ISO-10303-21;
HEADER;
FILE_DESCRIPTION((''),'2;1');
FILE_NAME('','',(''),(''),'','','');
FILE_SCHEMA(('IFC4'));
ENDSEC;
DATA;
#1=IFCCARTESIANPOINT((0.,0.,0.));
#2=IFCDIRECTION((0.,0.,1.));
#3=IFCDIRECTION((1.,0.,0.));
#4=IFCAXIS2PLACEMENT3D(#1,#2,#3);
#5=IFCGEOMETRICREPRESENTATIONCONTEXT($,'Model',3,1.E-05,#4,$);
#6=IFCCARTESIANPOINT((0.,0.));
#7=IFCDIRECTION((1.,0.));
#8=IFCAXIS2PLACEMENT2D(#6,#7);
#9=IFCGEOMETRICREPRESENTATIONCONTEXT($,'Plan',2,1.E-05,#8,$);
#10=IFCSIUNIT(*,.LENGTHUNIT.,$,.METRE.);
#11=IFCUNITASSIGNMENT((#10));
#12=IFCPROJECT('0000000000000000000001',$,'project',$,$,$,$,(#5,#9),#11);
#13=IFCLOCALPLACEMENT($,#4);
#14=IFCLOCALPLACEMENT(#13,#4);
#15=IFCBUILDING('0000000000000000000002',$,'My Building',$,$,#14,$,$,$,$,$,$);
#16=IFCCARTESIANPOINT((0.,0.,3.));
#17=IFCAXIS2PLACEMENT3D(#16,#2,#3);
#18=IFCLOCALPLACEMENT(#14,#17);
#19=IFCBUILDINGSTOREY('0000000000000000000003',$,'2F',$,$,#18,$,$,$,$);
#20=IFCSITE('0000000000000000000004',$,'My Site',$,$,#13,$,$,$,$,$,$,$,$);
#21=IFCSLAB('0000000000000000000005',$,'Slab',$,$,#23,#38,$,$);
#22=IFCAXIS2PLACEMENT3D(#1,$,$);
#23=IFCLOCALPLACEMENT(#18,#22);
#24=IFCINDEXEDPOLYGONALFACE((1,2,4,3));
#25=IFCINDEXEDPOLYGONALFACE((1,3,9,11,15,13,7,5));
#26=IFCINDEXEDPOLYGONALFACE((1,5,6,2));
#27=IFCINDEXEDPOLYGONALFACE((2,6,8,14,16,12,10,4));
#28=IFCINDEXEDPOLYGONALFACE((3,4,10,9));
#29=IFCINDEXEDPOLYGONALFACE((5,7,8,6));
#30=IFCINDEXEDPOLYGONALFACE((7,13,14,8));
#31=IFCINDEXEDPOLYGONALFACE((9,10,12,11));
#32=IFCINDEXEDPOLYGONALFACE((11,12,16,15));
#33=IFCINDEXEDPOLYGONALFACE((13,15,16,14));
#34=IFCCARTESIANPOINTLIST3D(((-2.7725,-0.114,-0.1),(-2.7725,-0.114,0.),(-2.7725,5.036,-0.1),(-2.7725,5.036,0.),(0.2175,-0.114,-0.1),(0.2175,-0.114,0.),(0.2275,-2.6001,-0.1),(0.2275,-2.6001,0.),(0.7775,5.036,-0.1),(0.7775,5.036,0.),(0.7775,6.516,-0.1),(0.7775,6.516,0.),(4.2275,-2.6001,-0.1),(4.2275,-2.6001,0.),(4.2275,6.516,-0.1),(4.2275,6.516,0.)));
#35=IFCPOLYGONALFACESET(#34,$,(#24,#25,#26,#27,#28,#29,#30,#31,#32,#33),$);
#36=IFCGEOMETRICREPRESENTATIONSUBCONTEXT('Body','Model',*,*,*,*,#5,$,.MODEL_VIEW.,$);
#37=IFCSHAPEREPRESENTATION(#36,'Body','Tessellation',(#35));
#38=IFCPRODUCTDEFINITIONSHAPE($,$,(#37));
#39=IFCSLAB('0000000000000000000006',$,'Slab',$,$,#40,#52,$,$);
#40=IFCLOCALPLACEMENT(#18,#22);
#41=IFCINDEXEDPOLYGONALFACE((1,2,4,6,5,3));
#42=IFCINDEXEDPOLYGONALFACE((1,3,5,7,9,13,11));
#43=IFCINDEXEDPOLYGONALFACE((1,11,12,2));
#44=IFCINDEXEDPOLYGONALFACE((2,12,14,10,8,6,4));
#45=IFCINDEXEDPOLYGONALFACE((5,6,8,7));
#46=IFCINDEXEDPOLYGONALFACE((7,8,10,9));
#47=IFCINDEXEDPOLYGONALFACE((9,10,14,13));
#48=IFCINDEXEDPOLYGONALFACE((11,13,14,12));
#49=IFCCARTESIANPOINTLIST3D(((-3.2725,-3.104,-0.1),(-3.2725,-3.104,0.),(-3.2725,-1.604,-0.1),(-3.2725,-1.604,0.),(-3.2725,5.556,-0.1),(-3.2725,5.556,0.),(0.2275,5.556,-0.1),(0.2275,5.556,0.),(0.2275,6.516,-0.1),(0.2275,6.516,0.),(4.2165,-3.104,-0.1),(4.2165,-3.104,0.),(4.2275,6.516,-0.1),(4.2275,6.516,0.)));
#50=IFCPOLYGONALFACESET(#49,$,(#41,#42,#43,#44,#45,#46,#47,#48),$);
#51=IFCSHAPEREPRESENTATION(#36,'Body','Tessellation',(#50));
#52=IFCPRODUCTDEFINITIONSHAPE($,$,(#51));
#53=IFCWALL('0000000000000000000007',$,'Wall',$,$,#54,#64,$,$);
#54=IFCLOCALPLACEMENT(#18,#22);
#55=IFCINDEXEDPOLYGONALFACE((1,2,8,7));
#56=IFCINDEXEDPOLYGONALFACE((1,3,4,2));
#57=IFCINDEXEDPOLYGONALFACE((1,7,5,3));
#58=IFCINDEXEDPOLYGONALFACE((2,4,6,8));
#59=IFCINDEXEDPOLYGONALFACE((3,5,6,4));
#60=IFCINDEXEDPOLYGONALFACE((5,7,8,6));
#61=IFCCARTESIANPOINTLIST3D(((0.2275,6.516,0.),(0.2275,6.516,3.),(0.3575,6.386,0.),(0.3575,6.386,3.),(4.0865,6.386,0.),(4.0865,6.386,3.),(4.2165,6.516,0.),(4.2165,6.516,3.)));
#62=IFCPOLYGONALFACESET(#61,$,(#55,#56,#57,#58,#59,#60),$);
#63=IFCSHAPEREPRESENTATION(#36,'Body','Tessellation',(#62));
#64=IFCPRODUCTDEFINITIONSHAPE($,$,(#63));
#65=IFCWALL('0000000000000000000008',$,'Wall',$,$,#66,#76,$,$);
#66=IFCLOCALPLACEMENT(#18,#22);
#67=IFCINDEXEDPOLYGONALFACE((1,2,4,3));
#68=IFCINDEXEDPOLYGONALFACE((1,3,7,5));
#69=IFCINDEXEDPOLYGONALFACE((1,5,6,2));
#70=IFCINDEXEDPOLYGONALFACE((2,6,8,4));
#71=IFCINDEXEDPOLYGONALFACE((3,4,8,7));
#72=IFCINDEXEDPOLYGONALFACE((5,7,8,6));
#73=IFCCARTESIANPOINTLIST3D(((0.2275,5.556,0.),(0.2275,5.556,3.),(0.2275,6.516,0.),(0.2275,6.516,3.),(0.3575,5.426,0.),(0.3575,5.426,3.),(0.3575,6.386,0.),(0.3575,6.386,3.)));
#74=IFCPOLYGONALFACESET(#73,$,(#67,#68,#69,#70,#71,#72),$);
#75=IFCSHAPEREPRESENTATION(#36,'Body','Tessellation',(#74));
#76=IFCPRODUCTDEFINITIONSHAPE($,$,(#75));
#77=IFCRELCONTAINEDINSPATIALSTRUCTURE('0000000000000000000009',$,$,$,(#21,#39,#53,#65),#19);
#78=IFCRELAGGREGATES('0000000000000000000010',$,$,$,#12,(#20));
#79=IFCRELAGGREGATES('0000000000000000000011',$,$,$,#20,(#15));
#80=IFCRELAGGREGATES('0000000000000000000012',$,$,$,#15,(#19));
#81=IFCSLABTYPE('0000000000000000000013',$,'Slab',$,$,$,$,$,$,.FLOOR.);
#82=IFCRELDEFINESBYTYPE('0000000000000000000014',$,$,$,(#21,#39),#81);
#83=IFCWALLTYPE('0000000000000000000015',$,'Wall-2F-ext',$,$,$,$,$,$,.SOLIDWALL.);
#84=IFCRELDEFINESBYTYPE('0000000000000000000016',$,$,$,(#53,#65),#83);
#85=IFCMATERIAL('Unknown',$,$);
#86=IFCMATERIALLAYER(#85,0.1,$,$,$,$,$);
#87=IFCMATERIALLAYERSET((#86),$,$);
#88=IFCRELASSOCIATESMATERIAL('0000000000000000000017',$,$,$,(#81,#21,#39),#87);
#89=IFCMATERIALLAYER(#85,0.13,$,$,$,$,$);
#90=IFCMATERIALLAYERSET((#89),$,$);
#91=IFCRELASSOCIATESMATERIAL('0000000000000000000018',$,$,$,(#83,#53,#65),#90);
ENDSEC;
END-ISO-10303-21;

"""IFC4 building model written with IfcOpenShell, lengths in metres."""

from ifc_helpers import new_model, si_unit, frame, origin_with_axes, origin_2d_with_axis, place, context, subcontext, project, spatial, line, indexed_curve, outline, extrude, material, layer, layer_set, layer_usage, type_object, element, save


model = new_model("IFC4")

# Units and contexts
model_context = context("Model", 3, precision=1e-05, world=origin_with_axes())
plan_context = context("Plan", 2, precision=1e-05, world=origin_2d_with_axis())
body_context_1 = subcontext(model_context, "Body", "Model", "MODEL_VIEW")
ifc_project = project(units=[si_unit("LENGTHUNIT", "METRE")], contexts=[model_context, plan_context])

# Site, building, storey
site_placement = place(None, origin_with_axes())
site = spatial("IfcSite", under=ifc_project, at=site_placement, Name="My Site")
building_placement = place(site_placement, origin_with_axes())
building = spatial("IfcBuilding", under=site, at=building_placement, Name="My Building")
storey_placement = place(building_placement, frame((0.0, 0.0, 3.0), z_axis=(0.0, 0.0, 1.0), x_axis=(1.0, 0.0, 0.0)))
storey = spatial("IfcBuildingStorey", under=building, at=storey_placement, Name="2F")

# Slabs
ifc_material = material(Name="Unknown")
ifc_layer_1 = layer(ifc_material, 0.1)
ifc_layer_set_1 = layer_set([ifc_layer_1])
ifc_layer_usage_1 = layer_usage(ifc_layer_set_1, "AXIS3", "POSITIVE", -0.1)
slab_type = type_object("IfcSlabType", Name="Slab", PredefinedType="FLOOR", material=ifc_layer_set_1)
slab_1_placement = place(storey_placement, frame((4.2275, 6.516, 0.0), z_axis=(0.0, 0.0, 1.0), x_axis=(1.0, 0.0, 0.0)))
element("IfcSlab", 1, at=slab_1_placement, inside=storey, type_object=slab_type, material=ifc_layer_usage_1, Name="Slab", context=body_context_1, shape_type="SweptSolid", body=[
    extrude(outline(indexed_curve([(0.0, 0.0), (-3.45, 0.0), (-3.45, -1.48), (-7.0, -1.48), (-7.0, -6.63), (-4.01, -6.63), (-4.0, -9.116), (0.0, -9.116), (0.0, 0.0)])), frame((0.0, 0.0, -0.1), z_axis=(0.0, 0.0, 1.0), x_axis=(1.0, 0.0, 0.0)), (0.0, 0.0, 1.0), 0.1),
])
ifc_layer_usage_2 = layer_usage(ifc_layer_set_1, "AXIS3", "POSITIVE", -0.1)
slab_2_placement = place(storey_placement, frame((4.2275, 6.516, 0.0), z_axis=(0.0, 0.0, 1.0), x_axis=(1.0, 0.0, 0.0)))
element("IfcSlab", 2, at=slab_2_placement, inside=storey, type_object=slab_type, material=ifc_layer_usage_2, Name="Slab", context=body_context_1, shape_type="SweptSolid", body=[
    extrude(outline(indexed_curve([(0.0, 0.0), (-4.0, 0.0), (-4.0, -0.96), (-7.5, -0.96), (-7.5, -8.12), (-7.5, -9.62), (-0.011, -9.62), (0.0, 0.0)])), frame((0.0, 0.0, -0.1), z_axis=(0.0, 0.0, 1.0), x_axis=(1.0, 0.0, 0.0)), (0.0, 0.0, 1.0), 0.1),
])

# Walls
ifc_layer_2 = layer(ifc_material, 0.13)
ifc_layer_set_2 = layer_set([ifc_layer_2])
ifc_layer_usage_3 = layer_usage(ifc_layer_set_2, "AXIS2", "POSITIVE", 0.0)
wall_type_1 = type_object("IfcWallType", Name="Wall-2F-ext", PredefinedType="SOLIDWALL", material=ifc_layer_set_2)
wall_1_placement = place(storey_placement, frame((4.2165, 6.516, 0.0), z_axis=(0.0, 0.0, 1.0), x_axis=(-1.0, 0.0, 0.0)))
element("IfcWall", 3, at=wall_1_placement, inside=storey, type_object=wall_type_1, material=ifc_layer_usage_3, Name="Wall", context=body_context_1, shape_type="SweptSolid", body=[
    extrude(outline(indexed_curve([(0.0, 0.0), (0.13, 0.13), (3.859, 0.13), (3.989, 0.0)], segments=[line(1, 2, 3, 4, 1)])), origin_with_axes(), (0.0, 0.0, 1.0), 3.0),
])
ifc_layer_usage_4 = layer_usage(ifc_layer_set_2, "AXIS2", "POSITIVE", 0.0)
wall_2_placement = place(storey_placement, frame((0.2275, 6.516, 0.0), z_axis=(0.0, 0.0, 1.0), x_axis=(0.0, -1.0, 0.0)))
element("IfcWall", 4, at=wall_2_placement, inside=storey, type_object=wall_type_1, material=ifc_layer_usage_4, Name="Wall", context=body_context_1, shape_type="SweptSolid", body=[
    extrude(outline(indexed_curve([(0.0, 0.0), (0.13, 0.13), (1.09, 0.13), (0.96, 0.0)], segments=[line(1, 2, 3, 4, 1)])), origin_with_axes(), (0.0, 0.0, 1.0), 3.0),
])

save(model, "model.ifc")
